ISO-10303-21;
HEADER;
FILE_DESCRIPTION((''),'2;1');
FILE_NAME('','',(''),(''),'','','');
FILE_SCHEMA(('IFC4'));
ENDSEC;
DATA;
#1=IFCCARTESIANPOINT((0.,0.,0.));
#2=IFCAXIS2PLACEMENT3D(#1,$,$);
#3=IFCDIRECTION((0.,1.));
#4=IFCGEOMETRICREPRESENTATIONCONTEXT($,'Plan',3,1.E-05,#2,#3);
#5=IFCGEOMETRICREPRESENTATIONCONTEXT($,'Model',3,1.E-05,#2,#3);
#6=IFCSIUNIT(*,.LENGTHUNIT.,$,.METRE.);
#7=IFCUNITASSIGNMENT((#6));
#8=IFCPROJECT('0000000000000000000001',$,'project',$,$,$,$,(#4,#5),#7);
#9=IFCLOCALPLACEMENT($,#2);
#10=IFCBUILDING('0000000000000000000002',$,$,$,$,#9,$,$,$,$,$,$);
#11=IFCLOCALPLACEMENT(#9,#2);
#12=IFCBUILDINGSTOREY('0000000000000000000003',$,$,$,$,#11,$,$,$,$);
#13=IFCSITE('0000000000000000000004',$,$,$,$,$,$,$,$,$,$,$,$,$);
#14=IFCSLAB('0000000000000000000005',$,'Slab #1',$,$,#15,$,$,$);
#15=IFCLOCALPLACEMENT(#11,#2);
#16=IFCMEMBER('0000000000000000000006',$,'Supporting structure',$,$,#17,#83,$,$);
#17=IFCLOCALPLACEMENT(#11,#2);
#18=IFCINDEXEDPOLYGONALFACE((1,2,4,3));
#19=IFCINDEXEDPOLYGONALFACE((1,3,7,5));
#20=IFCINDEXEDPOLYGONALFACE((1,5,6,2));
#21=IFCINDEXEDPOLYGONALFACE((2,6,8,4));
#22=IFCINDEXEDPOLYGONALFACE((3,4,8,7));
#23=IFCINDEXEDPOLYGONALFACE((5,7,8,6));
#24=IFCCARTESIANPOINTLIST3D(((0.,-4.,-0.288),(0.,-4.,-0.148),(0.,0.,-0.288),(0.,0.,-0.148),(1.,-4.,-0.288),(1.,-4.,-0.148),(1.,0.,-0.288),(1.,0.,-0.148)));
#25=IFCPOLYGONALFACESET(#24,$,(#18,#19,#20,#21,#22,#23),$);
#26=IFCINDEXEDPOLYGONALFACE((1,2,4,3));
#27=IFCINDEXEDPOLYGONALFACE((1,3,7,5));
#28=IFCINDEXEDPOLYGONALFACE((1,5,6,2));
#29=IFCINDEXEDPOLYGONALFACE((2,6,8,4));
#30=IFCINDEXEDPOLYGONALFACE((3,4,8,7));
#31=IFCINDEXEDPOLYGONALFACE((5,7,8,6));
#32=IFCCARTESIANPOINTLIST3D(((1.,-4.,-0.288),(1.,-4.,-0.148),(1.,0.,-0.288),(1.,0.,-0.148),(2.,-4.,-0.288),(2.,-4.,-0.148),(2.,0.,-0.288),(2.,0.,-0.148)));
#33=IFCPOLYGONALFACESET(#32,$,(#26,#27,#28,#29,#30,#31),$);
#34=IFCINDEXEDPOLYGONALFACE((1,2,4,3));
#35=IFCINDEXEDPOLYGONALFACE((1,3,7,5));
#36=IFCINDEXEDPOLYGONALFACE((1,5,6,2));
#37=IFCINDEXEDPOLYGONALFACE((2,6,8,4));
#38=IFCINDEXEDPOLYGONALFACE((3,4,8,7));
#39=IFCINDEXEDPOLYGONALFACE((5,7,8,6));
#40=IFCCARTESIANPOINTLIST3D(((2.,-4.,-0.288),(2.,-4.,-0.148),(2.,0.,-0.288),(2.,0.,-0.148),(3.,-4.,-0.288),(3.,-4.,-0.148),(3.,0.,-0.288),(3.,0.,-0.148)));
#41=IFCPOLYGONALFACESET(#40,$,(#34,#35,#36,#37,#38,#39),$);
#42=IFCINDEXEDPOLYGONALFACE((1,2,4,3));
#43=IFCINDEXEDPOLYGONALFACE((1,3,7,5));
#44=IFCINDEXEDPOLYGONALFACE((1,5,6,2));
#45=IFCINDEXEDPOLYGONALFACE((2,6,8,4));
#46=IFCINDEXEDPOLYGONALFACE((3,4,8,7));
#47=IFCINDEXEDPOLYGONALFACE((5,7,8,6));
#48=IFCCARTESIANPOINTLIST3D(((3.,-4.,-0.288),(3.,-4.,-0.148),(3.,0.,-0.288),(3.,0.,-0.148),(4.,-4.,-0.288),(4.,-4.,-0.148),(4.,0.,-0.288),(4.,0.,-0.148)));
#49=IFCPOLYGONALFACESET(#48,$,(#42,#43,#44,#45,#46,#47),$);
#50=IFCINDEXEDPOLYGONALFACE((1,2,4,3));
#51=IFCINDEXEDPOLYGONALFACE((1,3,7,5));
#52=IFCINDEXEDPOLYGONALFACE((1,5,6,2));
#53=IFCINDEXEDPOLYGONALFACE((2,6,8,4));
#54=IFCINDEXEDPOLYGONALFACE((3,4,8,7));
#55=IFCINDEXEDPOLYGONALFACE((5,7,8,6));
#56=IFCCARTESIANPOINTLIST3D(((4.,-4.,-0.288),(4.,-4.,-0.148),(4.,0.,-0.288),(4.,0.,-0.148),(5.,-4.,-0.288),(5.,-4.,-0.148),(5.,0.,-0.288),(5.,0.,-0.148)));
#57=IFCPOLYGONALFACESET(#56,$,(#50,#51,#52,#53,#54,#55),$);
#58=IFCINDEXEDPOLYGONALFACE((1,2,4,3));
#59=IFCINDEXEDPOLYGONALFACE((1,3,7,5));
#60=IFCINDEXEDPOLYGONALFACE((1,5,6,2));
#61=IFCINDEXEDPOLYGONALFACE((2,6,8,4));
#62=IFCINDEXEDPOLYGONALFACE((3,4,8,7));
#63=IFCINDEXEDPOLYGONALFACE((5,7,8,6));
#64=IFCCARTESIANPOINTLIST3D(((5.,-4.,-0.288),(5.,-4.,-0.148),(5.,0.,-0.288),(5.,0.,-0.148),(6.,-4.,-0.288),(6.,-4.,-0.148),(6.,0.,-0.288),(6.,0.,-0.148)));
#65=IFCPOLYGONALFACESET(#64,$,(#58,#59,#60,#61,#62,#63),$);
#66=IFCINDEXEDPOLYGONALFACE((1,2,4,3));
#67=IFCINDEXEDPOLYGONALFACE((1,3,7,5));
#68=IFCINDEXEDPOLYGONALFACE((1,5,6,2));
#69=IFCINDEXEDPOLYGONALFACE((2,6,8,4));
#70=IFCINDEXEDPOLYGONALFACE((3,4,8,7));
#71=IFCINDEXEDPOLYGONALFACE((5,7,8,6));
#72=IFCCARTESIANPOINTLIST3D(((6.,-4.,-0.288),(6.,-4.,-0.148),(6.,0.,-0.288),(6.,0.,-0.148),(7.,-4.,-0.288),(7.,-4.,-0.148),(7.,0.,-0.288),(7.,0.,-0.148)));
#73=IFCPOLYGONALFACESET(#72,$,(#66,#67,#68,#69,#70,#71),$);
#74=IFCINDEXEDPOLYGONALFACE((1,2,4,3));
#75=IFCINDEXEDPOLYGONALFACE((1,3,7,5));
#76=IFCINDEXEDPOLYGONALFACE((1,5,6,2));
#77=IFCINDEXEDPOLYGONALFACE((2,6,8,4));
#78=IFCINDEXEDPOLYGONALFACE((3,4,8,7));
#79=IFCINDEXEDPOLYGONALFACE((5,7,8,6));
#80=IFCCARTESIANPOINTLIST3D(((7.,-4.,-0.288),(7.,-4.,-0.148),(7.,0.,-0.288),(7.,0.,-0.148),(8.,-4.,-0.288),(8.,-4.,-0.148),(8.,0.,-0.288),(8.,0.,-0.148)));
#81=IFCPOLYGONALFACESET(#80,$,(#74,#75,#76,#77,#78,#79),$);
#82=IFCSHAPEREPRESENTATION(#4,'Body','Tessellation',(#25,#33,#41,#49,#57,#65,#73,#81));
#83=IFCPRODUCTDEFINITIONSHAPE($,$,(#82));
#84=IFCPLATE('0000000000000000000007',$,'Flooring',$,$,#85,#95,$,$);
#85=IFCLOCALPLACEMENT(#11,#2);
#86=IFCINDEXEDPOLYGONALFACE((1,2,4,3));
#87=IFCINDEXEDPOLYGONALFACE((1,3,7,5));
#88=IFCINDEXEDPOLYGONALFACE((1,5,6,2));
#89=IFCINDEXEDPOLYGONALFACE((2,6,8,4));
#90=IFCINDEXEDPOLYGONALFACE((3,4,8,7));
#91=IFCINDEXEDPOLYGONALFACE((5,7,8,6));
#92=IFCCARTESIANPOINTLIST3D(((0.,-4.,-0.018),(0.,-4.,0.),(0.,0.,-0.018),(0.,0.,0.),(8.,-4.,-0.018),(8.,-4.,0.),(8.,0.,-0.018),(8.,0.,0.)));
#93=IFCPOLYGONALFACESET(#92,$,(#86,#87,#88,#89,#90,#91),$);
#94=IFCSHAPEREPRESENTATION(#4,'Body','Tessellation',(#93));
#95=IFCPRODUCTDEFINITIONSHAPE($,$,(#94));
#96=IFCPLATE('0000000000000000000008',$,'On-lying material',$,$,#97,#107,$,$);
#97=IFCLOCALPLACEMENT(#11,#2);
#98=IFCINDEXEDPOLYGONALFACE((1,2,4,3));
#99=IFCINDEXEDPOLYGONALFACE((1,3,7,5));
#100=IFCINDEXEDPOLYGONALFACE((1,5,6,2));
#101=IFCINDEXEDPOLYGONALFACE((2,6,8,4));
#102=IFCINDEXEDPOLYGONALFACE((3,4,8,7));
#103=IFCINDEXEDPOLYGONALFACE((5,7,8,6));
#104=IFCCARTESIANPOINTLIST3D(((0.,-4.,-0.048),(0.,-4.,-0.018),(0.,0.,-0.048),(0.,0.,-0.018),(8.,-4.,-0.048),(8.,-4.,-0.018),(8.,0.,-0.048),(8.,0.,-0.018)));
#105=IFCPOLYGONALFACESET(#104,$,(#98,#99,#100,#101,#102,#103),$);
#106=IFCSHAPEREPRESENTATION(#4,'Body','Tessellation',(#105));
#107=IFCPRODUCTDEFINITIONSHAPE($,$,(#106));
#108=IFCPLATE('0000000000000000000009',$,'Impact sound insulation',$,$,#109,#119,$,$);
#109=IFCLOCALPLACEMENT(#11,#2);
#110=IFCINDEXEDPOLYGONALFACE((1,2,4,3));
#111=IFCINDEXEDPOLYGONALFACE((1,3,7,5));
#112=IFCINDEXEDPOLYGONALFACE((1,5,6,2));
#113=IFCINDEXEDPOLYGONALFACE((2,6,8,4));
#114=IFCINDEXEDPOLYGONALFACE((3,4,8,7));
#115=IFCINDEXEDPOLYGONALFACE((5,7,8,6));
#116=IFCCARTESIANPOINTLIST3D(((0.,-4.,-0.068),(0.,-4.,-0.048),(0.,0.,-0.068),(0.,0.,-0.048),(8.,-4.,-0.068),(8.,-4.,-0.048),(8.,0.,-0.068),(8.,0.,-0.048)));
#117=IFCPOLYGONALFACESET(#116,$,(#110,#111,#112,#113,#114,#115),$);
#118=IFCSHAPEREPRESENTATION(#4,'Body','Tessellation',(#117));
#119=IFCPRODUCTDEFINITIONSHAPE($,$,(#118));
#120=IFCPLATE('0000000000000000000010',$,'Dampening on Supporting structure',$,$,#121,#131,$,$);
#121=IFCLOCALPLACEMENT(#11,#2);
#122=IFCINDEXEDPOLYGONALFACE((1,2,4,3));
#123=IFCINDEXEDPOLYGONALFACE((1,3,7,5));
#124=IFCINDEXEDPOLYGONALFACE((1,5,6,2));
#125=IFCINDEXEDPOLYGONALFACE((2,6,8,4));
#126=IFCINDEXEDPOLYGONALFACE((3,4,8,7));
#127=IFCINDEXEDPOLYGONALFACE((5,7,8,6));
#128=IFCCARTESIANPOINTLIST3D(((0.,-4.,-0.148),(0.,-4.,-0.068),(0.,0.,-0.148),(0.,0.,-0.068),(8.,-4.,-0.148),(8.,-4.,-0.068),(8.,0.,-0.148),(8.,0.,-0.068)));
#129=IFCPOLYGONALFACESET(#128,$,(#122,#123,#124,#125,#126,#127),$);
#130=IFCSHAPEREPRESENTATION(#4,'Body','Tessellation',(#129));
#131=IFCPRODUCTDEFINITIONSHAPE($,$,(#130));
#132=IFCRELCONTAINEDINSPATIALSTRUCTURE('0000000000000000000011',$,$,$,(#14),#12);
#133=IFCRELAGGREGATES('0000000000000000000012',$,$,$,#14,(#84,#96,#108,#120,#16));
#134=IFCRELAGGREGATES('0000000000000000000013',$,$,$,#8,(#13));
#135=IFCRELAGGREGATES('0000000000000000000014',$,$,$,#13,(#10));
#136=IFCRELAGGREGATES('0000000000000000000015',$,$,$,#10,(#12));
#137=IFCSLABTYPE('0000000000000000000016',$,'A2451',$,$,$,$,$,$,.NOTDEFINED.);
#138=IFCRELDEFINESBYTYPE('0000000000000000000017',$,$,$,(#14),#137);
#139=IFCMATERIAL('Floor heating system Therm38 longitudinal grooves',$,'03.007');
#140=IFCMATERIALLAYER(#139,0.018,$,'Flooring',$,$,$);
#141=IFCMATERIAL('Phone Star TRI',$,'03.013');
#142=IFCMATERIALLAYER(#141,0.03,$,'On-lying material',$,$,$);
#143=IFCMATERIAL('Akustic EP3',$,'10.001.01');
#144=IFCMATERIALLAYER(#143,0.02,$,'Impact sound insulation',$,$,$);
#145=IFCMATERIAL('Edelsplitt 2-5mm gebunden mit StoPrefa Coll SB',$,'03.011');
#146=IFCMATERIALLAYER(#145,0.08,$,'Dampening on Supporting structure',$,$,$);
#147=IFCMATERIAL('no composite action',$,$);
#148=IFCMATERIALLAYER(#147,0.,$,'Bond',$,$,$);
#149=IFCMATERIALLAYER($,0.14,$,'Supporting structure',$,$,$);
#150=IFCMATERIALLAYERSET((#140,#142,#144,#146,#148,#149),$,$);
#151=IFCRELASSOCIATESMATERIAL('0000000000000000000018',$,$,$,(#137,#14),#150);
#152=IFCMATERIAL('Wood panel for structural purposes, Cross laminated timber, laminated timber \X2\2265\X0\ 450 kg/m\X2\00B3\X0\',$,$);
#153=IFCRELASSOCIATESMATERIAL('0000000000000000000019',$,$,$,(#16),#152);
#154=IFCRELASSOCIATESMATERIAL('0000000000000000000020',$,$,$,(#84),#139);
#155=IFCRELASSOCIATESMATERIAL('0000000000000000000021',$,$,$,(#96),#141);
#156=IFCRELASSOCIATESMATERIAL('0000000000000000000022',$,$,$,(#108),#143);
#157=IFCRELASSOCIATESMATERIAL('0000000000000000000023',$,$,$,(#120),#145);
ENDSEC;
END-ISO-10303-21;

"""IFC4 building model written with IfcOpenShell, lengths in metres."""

from ifc_helpers import new_model, si_unit, direction, frame, frame_2d, origin, origin_with_axes, place, context, project, spatial, rectangle, extrude, material, layer, layer_set, type_object, element, aggregate, save


model = new_model("IFC4")

# Units and contexts
plan_context = context("Plan", 3, precision=1e-05, world=origin(), true_north=direction((0.0, 1.0)))
model_context = context("Model", 3, precision=1e-05, world=origin(), true_north=direction((0.0, 1.0)))
ifc_project = project(units=[si_unit("LENGTHUNIT", "METRE")], contexts=[plan_context, model_context])

# Site, building, storey
site = spatial("IfcSite", under=ifc_project)
building_placement = place(None, origin())
building = spatial("IfcBuilding", under=site, at=building_placement)
storey_placement = place(building_placement, origin())
storey = spatial("IfcBuildingStorey", under=building, at=storey_placement)

# Slab, member, plates
ifc_material_1 = material(Name="Floor heating system Therm38 longitudinal grooves", Category="03.007")
ifc_layer_1 = layer(ifc_material_1, 0.018, Name="Flooring")
ifc_material_2 = material(Name="Phone Star TRI", Category="03.013")
ifc_layer_2 = layer(ifc_material_2, 0.03, Name="On-lying material")
ifc_material_3 = material(Name="Akustic EP3", Category="10.001.01")
ifc_layer_3 = layer(ifc_material_3, 0.02, Name="Impact sound insulation")
ifc_material_4 = material(Name="Edelsplitt 2-5mm gebunden mit StoPrefa Coll SB", Category="03.011")
ifc_layer_4 = layer(ifc_material_4, 0.08, Name="Dampening on Supporting structure")
ifc_material_5 = material(Name="no composite action")
ifc_layer_5 = layer(ifc_material_5, 0.0, Name="Bond")
ifc_layer_6 = layer(None, 0.14, Name="Supporting structure")
ifc_layer_set = layer_set([ifc_layer_1, ifc_layer_2, ifc_layer_3, ifc_layer_4, ifc_layer_5, ifc_layer_6])
slab_type = type_object("IfcSlabType", Name="A2451", PredefinedType="NOTDEFINED", material=ifc_layer_set)
slab_placement = place(None, frame((0.0, 0.0, 0.0), z_axis=(0.0, 0.0, -1.0), x_axis=(1.0, 0.0, 0.0)))
slab = element("IfcSlab", 1, at=slab_placement, inside=storey, type_object=slab_type, material=ifc_layer_set, Name="Slab #1")
ifc_material_6 = material(Name="Wood panel for structural purposes, Cross laminated timber, laminated timber ≥ 450 kg/m³")
member_placement = place(slab_placement, origin())
member = element("IfcMember", 2, at=member_placement, material=ifc_material_6, Name="Supporting structure", context=plan_context, shape_type="SweptSolid", body=[
    extrude(rectangle(XDim=1.0, YDim=0.14, at=frame_2d((0.5, 0.07), x_axis=(1.0, 0.0))), frame((0.0, 4.0, 0.148), z_axis=(0.0, -1.0, 0.0), x_axis=(1.0, 0.0, 0.0)), (0.0, 0.0, 1.0), 4.0),
    extrude(rectangle(XDim=1.0, YDim=0.14, at=frame_2d((0.5, 0.07), x_axis=(1.0, 0.0))), frame((1.0, 4.0, 0.148), z_axis=(0.0, -1.0, 0.0), x_axis=(1.0, 0.0, 0.0)), (0.0, 0.0, 1.0), 4.0),
    extrude(rectangle(XDim=1.0, YDim=0.14, at=frame_2d((0.5, 0.07), x_axis=(1.0, 0.0))), frame((2.0, 4.0, 0.148), z_axis=(0.0, -1.0, 0.0), x_axis=(1.0, 0.0, 0.0)), (0.0, 0.0, 1.0), 4.0),
    extrude(rectangle(XDim=1.0, YDim=0.14, at=frame_2d((0.5, 0.07), x_axis=(1.0, 0.0))), frame((3.0, 4.0, 0.148), z_axis=(0.0, -1.0, 0.0), x_axis=(1.0, 0.0, 0.0)), (0.0, 0.0, 1.0), 4.0),
    extrude(rectangle(XDim=1.0, YDim=0.14, at=frame_2d((0.5, 0.07), x_axis=(1.0, 0.0))), frame((4.0, 4.0, 0.148), z_axis=(0.0, -1.0, 0.0), x_axis=(1.0, 0.0, 0.0)), (0.0, 0.0, 1.0), 4.0),
    extrude(rectangle(XDim=1.0, YDim=0.14, at=frame_2d((0.5, 0.07), x_axis=(1.0, 0.0))), frame((5.0, 4.0, 0.148), z_axis=(0.0, -1.0, 0.0), x_axis=(1.0, 0.0, 0.0)), (0.0, 0.0, 1.0), 4.0),
    extrude(rectangle(XDim=1.0, YDim=0.14, at=frame_2d((0.5, 0.07), x_axis=(1.0, 0.0))), frame((6.0, 4.0, 0.148), z_axis=(0.0, -1.0, 0.0), x_axis=(1.0, 0.0, 0.0)), (0.0, 0.0, 1.0), 4.0),
    extrude(rectangle(XDim=1.0, YDim=0.14, at=frame_2d((0.5, 0.07), x_axis=(1.0, 0.0))), frame((7.0, 4.0, 0.148), z_axis=(0.0, -1.0, 0.0), x_axis=(1.0, 0.0, 0.0)), (0.0, 0.0, 1.0), 4.0),
])
plate_1_placement = place(slab_placement, origin())
plate_1 = element("IfcPlate", 3, at=plate_1_placement, material=ifc_material_1, Name="Flooring", context=plan_context, shape_type="SweptSolid", body=[
    extrude(rectangle(XDim=8.0, YDim=4.0, at=frame_2d((4.0, 2.0), x_axis=(1.0, 0.0))), origin_with_axes(), (0.0, 0.0, 1.0), 0.018),
])
plate_2_placement = place(slab_placement, origin())
plate_2 = element("IfcPlate", 4, at=plate_2_placement, material=ifc_material_2, Name="On-lying material", context=plan_context, shape_type="SweptSolid", body=[
    extrude(rectangle(XDim=8.0, YDim=4.0, at=frame_2d((4.0, 2.0), x_axis=(1.0, 0.0))), frame((0.0, 0.0, 0.018), z_axis=(0.0, 0.0, 1.0), x_axis=(1.0, 0.0, 0.0)), (0.0, 0.0, 1.0), 0.03),
])
plate_3_placement = place(slab_placement, origin())
plate_3 = element("IfcPlate", 5, at=plate_3_placement, material=ifc_material_3, Name="Impact sound insulation", context=plan_context, shape_type="SweptSolid", body=[
    extrude(rectangle(XDim=8.0, YDim=4.0, at=frame_2d((4.0, 2.0), x_axis=(1.0, 0.0))), frame((0.0, 0.0, 0.048), z_axis=(0.0, 0.0, 1.0), x_axis=(1.0, 0.0, 0.0)), (0.0, 0.0, 1.0), 0.02),
])
plate_4_placement = place(slab_placement, origin())
plate_4 = element("IfcPlate", 6, at=plate_4_placement, material=ifc_material_4, Name="Dampening on Supporting structure", context=plan_context, shape_type="SweptSolid", body=[
    extrude(rectangle(XDim=8.0, YDim=4.0, at=frame_2d((4.0, 2.0), x_axis=(1.0, 0.0))), frame((0.0, 0.0, 0.068), z_axis=(0.0, 0.0, 1.0), x_axis=(1.0, 0.0, 0.0)), (0.0, 0.0, 1.0), 0.08),
])
aggregate(slab, [plate_1, plate_2, plate_3, plate_4, member])

save(model, "model.ifc")
